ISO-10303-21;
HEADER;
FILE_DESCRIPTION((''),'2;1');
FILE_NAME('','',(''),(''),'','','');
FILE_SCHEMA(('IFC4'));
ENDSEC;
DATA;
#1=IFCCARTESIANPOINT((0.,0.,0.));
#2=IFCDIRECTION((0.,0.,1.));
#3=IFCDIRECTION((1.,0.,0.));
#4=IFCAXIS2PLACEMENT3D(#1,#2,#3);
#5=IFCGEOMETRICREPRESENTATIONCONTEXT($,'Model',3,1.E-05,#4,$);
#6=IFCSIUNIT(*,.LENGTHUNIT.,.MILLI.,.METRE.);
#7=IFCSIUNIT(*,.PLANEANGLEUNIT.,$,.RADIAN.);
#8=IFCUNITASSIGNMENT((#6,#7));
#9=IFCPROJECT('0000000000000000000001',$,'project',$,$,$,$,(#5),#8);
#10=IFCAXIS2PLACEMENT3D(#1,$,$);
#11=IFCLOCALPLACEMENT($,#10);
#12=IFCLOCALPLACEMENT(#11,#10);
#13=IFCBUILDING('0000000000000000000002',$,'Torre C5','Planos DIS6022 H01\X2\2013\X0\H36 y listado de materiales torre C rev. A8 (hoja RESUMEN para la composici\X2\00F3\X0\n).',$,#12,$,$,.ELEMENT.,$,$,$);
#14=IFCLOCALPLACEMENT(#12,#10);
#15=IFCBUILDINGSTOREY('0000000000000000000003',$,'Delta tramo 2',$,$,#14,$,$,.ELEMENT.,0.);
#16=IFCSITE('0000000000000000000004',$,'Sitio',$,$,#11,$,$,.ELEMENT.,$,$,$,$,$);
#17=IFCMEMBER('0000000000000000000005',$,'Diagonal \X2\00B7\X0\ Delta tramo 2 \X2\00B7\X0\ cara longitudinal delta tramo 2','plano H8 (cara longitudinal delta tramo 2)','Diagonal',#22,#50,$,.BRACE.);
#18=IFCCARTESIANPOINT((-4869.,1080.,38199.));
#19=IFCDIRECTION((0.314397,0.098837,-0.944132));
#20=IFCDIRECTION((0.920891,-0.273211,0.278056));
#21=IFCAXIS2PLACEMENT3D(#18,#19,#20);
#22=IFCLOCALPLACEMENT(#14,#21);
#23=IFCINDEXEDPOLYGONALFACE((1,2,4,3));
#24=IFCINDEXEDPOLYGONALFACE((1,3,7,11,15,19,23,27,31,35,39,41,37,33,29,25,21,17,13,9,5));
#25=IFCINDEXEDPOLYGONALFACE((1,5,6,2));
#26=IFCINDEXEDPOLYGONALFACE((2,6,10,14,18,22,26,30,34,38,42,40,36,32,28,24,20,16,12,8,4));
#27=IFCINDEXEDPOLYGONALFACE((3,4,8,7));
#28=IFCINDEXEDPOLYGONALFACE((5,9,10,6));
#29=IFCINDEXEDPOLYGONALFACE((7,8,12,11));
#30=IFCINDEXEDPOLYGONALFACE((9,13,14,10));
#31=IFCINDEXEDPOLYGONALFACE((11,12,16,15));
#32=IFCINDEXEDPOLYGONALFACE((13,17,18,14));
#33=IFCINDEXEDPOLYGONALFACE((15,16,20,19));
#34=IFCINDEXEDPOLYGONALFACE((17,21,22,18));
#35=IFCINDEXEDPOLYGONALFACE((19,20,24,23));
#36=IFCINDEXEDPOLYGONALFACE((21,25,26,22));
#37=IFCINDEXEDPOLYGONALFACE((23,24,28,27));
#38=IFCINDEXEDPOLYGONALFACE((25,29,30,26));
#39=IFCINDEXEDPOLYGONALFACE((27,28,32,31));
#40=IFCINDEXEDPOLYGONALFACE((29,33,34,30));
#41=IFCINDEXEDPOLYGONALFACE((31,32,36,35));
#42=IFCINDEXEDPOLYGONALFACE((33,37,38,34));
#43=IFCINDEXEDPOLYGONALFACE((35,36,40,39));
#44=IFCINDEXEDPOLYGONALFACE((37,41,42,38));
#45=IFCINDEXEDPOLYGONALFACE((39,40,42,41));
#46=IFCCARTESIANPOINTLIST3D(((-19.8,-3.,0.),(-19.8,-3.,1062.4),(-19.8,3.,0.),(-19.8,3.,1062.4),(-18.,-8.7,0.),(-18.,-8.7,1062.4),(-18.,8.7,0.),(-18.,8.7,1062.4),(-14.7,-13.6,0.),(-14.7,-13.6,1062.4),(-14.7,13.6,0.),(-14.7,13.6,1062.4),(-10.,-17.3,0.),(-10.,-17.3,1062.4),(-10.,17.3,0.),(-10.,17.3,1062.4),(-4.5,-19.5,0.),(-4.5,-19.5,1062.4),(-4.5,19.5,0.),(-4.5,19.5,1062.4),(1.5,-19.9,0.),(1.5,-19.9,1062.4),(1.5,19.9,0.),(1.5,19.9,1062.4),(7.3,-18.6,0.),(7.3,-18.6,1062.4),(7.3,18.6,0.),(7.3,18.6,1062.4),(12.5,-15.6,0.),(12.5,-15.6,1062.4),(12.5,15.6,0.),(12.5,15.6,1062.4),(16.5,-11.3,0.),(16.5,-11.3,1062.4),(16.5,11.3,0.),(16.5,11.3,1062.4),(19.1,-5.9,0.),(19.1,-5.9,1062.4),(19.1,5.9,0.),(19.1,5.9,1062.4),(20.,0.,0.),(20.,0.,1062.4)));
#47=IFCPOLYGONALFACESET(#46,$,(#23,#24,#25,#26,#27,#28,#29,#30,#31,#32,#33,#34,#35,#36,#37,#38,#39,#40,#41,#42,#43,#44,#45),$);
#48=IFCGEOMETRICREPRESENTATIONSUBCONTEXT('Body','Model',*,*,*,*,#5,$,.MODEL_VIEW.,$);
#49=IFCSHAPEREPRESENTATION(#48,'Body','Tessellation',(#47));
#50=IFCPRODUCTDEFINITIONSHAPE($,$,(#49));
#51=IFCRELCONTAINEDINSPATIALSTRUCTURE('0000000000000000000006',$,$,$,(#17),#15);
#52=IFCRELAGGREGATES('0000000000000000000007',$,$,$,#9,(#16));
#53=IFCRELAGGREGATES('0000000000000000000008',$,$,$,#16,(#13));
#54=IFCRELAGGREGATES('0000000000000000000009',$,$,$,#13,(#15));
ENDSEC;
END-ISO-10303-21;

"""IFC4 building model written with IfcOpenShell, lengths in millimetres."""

from ifc_helpers import new_model, si_unit, frame, origin, origin_with_axes, place, context, subcontext, project, spatial, circle, extrude, element, save


model = new_model("IFC4")

# Units and contexts
model_context = context("Model", 3, precision=1e-05, world=origin_with_axes())
body_context = subcontext(model_context, "Body", "Model", "MODEL_VIEW")
ifc_project = project(units=[si_unit("LENGTHUNIT", "METRE", prefix="MILLI"), si_unit("PLANEANGLEUNIT", "RADIAN")], contexts=[model_context])

# Site, building, storey
site_placement = place(None, origin())
site = spatial("IfcSite", under=ifc_project, at=site_placement, Name="Sitio", CompositionType="ELEMENT")
building_placement = place(site_placement, origin())
building = spatial("IfcBuilding", under=site, at=building_placement, Name="Torre C5", Description="Planos DIS6022 H01–H36 y listado de materiales torre C rev. A8 (hoja RESUMEN para la composición).", CompositionType="ELEMENT")
storey_placement = place(building_placement, origin())
storey = spatial("IfcBuildingStorey", under=building, at=storey_placement, Name="Delta tramo 2", CompositionType="ELEMENT", Elevation=0.0)

# Member
member_1_placement = place(storey_placement, frame((-4869.0, 1080.0, 38199.0), z_axis=(0.314397, 0.098837, -0.944132), x_axis=(0.920891, -0.273211, 0.278056)))
element("IfcMember", 1, at=member_1_placement, inside=storey, Name="Diagonal · Delta tramo 2 · cara longitudinal delta tramo 2", Description="plano H8 (cara longitudinal delta tramo 2)", ObjectType="Diagonal", PredefinedType="BRACE", context=body_context, shape_type="SweptSolid", body=[
    extrude(circle(Radius=20.0), None, (0.0, 0.0, 1.0), 1062.4),
])

save(model, "model.ifc")
